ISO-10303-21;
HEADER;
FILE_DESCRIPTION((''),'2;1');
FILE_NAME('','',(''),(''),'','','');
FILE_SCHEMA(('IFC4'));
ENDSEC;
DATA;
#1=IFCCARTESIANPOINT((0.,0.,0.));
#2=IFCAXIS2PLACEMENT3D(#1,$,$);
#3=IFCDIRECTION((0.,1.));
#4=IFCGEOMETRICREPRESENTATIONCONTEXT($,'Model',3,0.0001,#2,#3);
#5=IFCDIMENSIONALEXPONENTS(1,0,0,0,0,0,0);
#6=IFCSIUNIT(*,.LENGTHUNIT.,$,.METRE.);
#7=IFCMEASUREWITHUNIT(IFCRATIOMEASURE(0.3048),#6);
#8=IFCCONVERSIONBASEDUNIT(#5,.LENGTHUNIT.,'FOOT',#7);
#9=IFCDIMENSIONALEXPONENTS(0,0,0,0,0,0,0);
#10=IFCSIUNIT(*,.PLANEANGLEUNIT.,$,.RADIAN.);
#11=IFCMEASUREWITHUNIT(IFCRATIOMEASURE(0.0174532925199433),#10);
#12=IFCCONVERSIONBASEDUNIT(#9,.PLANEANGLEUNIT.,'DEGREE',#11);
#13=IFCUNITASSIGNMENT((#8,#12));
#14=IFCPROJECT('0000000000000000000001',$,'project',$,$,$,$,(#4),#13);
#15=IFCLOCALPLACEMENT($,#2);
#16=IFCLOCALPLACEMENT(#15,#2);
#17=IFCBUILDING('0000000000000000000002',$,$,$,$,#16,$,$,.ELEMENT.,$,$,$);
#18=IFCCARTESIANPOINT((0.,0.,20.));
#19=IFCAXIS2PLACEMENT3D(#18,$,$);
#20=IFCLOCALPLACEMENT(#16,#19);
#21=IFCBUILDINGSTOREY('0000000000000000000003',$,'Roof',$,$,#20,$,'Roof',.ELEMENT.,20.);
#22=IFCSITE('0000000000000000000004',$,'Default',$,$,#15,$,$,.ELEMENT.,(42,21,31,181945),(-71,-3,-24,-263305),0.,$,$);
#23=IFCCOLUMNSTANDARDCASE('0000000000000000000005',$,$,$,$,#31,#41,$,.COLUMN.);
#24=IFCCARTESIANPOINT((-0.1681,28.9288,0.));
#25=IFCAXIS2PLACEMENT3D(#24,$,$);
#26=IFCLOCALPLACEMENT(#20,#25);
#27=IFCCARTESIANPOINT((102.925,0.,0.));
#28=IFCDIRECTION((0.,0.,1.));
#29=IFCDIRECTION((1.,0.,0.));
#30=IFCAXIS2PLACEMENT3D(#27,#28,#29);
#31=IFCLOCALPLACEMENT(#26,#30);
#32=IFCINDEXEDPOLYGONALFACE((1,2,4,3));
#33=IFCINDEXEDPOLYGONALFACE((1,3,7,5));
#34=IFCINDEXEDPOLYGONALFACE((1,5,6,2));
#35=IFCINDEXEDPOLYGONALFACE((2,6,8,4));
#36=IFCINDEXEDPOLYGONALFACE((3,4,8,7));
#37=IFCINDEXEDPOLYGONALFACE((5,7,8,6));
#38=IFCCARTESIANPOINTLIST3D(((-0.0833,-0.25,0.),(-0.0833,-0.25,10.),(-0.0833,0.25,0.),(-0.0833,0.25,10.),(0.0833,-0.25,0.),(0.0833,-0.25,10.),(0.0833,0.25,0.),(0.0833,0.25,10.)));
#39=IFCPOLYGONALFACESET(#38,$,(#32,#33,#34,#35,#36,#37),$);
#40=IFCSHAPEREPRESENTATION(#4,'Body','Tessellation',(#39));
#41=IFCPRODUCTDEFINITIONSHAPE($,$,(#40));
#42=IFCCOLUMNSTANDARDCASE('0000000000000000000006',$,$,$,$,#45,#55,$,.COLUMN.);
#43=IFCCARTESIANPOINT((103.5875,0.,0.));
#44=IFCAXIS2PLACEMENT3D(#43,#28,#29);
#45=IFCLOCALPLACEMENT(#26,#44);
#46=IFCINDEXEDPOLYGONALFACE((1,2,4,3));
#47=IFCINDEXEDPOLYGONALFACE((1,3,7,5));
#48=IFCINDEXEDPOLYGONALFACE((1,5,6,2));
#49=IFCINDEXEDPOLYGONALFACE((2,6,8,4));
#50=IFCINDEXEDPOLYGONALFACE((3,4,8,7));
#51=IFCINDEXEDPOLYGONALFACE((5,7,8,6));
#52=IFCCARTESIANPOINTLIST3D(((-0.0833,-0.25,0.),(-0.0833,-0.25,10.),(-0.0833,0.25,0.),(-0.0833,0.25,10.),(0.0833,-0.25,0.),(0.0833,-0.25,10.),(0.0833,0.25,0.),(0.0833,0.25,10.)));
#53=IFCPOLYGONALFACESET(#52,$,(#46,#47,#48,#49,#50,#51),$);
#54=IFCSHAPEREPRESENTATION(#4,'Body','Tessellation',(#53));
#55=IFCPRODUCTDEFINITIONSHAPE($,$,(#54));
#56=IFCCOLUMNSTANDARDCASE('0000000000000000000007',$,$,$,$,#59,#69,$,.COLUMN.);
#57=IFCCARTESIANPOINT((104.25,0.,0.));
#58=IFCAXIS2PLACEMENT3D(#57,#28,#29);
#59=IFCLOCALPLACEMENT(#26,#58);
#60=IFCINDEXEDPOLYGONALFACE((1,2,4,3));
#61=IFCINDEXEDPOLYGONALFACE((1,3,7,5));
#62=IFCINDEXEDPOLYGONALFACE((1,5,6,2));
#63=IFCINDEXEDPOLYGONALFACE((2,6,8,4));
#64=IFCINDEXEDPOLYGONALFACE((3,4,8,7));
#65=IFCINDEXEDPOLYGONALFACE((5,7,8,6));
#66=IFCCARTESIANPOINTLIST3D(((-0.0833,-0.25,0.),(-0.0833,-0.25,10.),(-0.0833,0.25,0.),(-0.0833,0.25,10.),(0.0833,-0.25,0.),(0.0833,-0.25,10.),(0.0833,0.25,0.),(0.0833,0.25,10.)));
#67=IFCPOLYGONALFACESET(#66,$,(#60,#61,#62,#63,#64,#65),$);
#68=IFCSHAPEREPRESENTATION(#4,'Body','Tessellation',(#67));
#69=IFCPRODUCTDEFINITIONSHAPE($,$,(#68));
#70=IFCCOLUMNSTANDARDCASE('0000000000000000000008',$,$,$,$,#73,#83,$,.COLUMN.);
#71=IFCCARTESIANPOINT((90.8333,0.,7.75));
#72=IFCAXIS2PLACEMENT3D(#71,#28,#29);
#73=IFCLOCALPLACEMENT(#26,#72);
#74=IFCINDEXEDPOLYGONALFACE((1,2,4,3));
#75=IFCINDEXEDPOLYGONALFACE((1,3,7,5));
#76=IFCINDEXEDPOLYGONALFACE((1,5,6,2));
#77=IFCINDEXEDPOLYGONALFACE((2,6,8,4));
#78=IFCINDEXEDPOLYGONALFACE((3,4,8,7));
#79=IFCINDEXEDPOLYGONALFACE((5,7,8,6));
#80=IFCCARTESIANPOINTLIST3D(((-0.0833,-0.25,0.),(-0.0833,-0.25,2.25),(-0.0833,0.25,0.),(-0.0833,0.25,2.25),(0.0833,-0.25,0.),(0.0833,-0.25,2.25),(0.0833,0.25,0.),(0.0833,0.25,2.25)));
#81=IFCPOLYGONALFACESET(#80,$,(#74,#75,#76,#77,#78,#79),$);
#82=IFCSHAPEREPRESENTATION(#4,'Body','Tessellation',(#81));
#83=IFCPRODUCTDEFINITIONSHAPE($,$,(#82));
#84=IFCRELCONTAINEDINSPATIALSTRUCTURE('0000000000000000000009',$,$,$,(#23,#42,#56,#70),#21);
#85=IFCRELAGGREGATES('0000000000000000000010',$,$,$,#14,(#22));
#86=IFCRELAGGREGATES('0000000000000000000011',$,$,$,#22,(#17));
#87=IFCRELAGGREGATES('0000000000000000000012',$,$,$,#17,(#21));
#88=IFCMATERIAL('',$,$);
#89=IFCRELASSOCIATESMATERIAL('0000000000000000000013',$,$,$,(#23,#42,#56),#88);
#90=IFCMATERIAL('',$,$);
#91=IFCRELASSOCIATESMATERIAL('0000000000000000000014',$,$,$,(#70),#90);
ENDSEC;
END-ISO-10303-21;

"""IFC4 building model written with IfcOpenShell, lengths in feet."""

from ifc_helpers import new_model, entity, si_unit, converted_unit, direction, frame, origin, place, context, project, spatial, rectangle, extrude, material, element, save


model = new_model("IFC4")

# Units and contexts
model_context = context("Model", 3, precision=0.0001, world=origin(), true_north=direction((0.0, 1.0)))
ifc_project = project(units=[converted_unit("LENGTHUNIT", "FOOT", entity("IfcRatioMeasure", 0.3048), si_unit("LENGTHUNIT", "METRE"), dimensions=[1, 0, 0, 0, 0, 0, 0]), converted_unit("PLANEANGLEUNIT", "DEGREE", entity("IfcRatioMeasure", 0.0174532925199433), si_unit("PLANEANGLEUNIT", "RADIAN"), dimensions=[0, 0, 0, 0, 0, 0, 0])], contexts=[model_context])

# Site, building, storey
site_placement = place(None, origin())
site = spatial("IfcSite", under=ifc_project, at=site_placement, Name="Default", CompositionType="ELEMENT", RefLatitude=(42, 21, 31, 181945), RefLongitude=(-71, -3, -24, -263305), RefElevation=0.0)
building_placement = place(site_placement, origin())
building = spatial("IfcBuilding", under=site, at=building_placement, CompositionType="ELEMENT")
storey_placement = place(building_placement, frame((0.0, 0.0, 20.0)))
storey = spatial("IfcBuildingStorey", under=building, at=storey_placement, Name="Roof", LongName="Roof", CompositionType="ELEMENT", Elevation=20.0)

# Columns
ifc_material_1 = material(Name="")
placement = place(storey_placement, frame((-0.1681, 28.9288, 0.0)))
for number, where, z_axis, x_axis in (
    (1, (102.925, 0.0, 0.0), (0.0, 0.0, 1.0), (1.0, 0.0, 0.0)),
    (2, (103.5875, 0.0, 0.0), (0.0, 0.0, 1.0), (1.0, 0.0, 0.0)),
    (3, (104.25, 0.0, 0.0), (0.0, 0.0, 1.0), (1.0, 0.0, 0.0)),
):
    element("IfcColumnStandardCase", number, at=place(placement, frame(where, z_axis=z_axis, x_axis=x_axis)), inside=storey, material=ifc_material_1, PredefinedType="COLUMN", context=model_context, shape_type="SweptSolid", body=[
        extrude(rectangle(XDim=0.1667, YDim=0.5), origin(), (0.0, 0.0, 1.0), 10.0),
    ])
ifc_material_2 = material(Name="")
for number, where, z_axis, x_axis in (
    (4, (90.8333, 0.0, 7.75), (0.0, 0.0, 1.0), (1.0, 0.0, 0.0)),
):
    element("IfcColumnStandardCase", number, at=place(placement, frame(where, z_axis=z_axis, x_axis=x_axis)), inside=storey, material=ifc_material_2, PredefinedType="COLUMN", context=model_context, shape_type="SweptSolid", body=[
        extrude(rectangle(XDim=0.1667, YDim=0.5), origin(), (0.0, 0.0, 1.0), 2.25),
    ])

save(model, "model.ifc")
